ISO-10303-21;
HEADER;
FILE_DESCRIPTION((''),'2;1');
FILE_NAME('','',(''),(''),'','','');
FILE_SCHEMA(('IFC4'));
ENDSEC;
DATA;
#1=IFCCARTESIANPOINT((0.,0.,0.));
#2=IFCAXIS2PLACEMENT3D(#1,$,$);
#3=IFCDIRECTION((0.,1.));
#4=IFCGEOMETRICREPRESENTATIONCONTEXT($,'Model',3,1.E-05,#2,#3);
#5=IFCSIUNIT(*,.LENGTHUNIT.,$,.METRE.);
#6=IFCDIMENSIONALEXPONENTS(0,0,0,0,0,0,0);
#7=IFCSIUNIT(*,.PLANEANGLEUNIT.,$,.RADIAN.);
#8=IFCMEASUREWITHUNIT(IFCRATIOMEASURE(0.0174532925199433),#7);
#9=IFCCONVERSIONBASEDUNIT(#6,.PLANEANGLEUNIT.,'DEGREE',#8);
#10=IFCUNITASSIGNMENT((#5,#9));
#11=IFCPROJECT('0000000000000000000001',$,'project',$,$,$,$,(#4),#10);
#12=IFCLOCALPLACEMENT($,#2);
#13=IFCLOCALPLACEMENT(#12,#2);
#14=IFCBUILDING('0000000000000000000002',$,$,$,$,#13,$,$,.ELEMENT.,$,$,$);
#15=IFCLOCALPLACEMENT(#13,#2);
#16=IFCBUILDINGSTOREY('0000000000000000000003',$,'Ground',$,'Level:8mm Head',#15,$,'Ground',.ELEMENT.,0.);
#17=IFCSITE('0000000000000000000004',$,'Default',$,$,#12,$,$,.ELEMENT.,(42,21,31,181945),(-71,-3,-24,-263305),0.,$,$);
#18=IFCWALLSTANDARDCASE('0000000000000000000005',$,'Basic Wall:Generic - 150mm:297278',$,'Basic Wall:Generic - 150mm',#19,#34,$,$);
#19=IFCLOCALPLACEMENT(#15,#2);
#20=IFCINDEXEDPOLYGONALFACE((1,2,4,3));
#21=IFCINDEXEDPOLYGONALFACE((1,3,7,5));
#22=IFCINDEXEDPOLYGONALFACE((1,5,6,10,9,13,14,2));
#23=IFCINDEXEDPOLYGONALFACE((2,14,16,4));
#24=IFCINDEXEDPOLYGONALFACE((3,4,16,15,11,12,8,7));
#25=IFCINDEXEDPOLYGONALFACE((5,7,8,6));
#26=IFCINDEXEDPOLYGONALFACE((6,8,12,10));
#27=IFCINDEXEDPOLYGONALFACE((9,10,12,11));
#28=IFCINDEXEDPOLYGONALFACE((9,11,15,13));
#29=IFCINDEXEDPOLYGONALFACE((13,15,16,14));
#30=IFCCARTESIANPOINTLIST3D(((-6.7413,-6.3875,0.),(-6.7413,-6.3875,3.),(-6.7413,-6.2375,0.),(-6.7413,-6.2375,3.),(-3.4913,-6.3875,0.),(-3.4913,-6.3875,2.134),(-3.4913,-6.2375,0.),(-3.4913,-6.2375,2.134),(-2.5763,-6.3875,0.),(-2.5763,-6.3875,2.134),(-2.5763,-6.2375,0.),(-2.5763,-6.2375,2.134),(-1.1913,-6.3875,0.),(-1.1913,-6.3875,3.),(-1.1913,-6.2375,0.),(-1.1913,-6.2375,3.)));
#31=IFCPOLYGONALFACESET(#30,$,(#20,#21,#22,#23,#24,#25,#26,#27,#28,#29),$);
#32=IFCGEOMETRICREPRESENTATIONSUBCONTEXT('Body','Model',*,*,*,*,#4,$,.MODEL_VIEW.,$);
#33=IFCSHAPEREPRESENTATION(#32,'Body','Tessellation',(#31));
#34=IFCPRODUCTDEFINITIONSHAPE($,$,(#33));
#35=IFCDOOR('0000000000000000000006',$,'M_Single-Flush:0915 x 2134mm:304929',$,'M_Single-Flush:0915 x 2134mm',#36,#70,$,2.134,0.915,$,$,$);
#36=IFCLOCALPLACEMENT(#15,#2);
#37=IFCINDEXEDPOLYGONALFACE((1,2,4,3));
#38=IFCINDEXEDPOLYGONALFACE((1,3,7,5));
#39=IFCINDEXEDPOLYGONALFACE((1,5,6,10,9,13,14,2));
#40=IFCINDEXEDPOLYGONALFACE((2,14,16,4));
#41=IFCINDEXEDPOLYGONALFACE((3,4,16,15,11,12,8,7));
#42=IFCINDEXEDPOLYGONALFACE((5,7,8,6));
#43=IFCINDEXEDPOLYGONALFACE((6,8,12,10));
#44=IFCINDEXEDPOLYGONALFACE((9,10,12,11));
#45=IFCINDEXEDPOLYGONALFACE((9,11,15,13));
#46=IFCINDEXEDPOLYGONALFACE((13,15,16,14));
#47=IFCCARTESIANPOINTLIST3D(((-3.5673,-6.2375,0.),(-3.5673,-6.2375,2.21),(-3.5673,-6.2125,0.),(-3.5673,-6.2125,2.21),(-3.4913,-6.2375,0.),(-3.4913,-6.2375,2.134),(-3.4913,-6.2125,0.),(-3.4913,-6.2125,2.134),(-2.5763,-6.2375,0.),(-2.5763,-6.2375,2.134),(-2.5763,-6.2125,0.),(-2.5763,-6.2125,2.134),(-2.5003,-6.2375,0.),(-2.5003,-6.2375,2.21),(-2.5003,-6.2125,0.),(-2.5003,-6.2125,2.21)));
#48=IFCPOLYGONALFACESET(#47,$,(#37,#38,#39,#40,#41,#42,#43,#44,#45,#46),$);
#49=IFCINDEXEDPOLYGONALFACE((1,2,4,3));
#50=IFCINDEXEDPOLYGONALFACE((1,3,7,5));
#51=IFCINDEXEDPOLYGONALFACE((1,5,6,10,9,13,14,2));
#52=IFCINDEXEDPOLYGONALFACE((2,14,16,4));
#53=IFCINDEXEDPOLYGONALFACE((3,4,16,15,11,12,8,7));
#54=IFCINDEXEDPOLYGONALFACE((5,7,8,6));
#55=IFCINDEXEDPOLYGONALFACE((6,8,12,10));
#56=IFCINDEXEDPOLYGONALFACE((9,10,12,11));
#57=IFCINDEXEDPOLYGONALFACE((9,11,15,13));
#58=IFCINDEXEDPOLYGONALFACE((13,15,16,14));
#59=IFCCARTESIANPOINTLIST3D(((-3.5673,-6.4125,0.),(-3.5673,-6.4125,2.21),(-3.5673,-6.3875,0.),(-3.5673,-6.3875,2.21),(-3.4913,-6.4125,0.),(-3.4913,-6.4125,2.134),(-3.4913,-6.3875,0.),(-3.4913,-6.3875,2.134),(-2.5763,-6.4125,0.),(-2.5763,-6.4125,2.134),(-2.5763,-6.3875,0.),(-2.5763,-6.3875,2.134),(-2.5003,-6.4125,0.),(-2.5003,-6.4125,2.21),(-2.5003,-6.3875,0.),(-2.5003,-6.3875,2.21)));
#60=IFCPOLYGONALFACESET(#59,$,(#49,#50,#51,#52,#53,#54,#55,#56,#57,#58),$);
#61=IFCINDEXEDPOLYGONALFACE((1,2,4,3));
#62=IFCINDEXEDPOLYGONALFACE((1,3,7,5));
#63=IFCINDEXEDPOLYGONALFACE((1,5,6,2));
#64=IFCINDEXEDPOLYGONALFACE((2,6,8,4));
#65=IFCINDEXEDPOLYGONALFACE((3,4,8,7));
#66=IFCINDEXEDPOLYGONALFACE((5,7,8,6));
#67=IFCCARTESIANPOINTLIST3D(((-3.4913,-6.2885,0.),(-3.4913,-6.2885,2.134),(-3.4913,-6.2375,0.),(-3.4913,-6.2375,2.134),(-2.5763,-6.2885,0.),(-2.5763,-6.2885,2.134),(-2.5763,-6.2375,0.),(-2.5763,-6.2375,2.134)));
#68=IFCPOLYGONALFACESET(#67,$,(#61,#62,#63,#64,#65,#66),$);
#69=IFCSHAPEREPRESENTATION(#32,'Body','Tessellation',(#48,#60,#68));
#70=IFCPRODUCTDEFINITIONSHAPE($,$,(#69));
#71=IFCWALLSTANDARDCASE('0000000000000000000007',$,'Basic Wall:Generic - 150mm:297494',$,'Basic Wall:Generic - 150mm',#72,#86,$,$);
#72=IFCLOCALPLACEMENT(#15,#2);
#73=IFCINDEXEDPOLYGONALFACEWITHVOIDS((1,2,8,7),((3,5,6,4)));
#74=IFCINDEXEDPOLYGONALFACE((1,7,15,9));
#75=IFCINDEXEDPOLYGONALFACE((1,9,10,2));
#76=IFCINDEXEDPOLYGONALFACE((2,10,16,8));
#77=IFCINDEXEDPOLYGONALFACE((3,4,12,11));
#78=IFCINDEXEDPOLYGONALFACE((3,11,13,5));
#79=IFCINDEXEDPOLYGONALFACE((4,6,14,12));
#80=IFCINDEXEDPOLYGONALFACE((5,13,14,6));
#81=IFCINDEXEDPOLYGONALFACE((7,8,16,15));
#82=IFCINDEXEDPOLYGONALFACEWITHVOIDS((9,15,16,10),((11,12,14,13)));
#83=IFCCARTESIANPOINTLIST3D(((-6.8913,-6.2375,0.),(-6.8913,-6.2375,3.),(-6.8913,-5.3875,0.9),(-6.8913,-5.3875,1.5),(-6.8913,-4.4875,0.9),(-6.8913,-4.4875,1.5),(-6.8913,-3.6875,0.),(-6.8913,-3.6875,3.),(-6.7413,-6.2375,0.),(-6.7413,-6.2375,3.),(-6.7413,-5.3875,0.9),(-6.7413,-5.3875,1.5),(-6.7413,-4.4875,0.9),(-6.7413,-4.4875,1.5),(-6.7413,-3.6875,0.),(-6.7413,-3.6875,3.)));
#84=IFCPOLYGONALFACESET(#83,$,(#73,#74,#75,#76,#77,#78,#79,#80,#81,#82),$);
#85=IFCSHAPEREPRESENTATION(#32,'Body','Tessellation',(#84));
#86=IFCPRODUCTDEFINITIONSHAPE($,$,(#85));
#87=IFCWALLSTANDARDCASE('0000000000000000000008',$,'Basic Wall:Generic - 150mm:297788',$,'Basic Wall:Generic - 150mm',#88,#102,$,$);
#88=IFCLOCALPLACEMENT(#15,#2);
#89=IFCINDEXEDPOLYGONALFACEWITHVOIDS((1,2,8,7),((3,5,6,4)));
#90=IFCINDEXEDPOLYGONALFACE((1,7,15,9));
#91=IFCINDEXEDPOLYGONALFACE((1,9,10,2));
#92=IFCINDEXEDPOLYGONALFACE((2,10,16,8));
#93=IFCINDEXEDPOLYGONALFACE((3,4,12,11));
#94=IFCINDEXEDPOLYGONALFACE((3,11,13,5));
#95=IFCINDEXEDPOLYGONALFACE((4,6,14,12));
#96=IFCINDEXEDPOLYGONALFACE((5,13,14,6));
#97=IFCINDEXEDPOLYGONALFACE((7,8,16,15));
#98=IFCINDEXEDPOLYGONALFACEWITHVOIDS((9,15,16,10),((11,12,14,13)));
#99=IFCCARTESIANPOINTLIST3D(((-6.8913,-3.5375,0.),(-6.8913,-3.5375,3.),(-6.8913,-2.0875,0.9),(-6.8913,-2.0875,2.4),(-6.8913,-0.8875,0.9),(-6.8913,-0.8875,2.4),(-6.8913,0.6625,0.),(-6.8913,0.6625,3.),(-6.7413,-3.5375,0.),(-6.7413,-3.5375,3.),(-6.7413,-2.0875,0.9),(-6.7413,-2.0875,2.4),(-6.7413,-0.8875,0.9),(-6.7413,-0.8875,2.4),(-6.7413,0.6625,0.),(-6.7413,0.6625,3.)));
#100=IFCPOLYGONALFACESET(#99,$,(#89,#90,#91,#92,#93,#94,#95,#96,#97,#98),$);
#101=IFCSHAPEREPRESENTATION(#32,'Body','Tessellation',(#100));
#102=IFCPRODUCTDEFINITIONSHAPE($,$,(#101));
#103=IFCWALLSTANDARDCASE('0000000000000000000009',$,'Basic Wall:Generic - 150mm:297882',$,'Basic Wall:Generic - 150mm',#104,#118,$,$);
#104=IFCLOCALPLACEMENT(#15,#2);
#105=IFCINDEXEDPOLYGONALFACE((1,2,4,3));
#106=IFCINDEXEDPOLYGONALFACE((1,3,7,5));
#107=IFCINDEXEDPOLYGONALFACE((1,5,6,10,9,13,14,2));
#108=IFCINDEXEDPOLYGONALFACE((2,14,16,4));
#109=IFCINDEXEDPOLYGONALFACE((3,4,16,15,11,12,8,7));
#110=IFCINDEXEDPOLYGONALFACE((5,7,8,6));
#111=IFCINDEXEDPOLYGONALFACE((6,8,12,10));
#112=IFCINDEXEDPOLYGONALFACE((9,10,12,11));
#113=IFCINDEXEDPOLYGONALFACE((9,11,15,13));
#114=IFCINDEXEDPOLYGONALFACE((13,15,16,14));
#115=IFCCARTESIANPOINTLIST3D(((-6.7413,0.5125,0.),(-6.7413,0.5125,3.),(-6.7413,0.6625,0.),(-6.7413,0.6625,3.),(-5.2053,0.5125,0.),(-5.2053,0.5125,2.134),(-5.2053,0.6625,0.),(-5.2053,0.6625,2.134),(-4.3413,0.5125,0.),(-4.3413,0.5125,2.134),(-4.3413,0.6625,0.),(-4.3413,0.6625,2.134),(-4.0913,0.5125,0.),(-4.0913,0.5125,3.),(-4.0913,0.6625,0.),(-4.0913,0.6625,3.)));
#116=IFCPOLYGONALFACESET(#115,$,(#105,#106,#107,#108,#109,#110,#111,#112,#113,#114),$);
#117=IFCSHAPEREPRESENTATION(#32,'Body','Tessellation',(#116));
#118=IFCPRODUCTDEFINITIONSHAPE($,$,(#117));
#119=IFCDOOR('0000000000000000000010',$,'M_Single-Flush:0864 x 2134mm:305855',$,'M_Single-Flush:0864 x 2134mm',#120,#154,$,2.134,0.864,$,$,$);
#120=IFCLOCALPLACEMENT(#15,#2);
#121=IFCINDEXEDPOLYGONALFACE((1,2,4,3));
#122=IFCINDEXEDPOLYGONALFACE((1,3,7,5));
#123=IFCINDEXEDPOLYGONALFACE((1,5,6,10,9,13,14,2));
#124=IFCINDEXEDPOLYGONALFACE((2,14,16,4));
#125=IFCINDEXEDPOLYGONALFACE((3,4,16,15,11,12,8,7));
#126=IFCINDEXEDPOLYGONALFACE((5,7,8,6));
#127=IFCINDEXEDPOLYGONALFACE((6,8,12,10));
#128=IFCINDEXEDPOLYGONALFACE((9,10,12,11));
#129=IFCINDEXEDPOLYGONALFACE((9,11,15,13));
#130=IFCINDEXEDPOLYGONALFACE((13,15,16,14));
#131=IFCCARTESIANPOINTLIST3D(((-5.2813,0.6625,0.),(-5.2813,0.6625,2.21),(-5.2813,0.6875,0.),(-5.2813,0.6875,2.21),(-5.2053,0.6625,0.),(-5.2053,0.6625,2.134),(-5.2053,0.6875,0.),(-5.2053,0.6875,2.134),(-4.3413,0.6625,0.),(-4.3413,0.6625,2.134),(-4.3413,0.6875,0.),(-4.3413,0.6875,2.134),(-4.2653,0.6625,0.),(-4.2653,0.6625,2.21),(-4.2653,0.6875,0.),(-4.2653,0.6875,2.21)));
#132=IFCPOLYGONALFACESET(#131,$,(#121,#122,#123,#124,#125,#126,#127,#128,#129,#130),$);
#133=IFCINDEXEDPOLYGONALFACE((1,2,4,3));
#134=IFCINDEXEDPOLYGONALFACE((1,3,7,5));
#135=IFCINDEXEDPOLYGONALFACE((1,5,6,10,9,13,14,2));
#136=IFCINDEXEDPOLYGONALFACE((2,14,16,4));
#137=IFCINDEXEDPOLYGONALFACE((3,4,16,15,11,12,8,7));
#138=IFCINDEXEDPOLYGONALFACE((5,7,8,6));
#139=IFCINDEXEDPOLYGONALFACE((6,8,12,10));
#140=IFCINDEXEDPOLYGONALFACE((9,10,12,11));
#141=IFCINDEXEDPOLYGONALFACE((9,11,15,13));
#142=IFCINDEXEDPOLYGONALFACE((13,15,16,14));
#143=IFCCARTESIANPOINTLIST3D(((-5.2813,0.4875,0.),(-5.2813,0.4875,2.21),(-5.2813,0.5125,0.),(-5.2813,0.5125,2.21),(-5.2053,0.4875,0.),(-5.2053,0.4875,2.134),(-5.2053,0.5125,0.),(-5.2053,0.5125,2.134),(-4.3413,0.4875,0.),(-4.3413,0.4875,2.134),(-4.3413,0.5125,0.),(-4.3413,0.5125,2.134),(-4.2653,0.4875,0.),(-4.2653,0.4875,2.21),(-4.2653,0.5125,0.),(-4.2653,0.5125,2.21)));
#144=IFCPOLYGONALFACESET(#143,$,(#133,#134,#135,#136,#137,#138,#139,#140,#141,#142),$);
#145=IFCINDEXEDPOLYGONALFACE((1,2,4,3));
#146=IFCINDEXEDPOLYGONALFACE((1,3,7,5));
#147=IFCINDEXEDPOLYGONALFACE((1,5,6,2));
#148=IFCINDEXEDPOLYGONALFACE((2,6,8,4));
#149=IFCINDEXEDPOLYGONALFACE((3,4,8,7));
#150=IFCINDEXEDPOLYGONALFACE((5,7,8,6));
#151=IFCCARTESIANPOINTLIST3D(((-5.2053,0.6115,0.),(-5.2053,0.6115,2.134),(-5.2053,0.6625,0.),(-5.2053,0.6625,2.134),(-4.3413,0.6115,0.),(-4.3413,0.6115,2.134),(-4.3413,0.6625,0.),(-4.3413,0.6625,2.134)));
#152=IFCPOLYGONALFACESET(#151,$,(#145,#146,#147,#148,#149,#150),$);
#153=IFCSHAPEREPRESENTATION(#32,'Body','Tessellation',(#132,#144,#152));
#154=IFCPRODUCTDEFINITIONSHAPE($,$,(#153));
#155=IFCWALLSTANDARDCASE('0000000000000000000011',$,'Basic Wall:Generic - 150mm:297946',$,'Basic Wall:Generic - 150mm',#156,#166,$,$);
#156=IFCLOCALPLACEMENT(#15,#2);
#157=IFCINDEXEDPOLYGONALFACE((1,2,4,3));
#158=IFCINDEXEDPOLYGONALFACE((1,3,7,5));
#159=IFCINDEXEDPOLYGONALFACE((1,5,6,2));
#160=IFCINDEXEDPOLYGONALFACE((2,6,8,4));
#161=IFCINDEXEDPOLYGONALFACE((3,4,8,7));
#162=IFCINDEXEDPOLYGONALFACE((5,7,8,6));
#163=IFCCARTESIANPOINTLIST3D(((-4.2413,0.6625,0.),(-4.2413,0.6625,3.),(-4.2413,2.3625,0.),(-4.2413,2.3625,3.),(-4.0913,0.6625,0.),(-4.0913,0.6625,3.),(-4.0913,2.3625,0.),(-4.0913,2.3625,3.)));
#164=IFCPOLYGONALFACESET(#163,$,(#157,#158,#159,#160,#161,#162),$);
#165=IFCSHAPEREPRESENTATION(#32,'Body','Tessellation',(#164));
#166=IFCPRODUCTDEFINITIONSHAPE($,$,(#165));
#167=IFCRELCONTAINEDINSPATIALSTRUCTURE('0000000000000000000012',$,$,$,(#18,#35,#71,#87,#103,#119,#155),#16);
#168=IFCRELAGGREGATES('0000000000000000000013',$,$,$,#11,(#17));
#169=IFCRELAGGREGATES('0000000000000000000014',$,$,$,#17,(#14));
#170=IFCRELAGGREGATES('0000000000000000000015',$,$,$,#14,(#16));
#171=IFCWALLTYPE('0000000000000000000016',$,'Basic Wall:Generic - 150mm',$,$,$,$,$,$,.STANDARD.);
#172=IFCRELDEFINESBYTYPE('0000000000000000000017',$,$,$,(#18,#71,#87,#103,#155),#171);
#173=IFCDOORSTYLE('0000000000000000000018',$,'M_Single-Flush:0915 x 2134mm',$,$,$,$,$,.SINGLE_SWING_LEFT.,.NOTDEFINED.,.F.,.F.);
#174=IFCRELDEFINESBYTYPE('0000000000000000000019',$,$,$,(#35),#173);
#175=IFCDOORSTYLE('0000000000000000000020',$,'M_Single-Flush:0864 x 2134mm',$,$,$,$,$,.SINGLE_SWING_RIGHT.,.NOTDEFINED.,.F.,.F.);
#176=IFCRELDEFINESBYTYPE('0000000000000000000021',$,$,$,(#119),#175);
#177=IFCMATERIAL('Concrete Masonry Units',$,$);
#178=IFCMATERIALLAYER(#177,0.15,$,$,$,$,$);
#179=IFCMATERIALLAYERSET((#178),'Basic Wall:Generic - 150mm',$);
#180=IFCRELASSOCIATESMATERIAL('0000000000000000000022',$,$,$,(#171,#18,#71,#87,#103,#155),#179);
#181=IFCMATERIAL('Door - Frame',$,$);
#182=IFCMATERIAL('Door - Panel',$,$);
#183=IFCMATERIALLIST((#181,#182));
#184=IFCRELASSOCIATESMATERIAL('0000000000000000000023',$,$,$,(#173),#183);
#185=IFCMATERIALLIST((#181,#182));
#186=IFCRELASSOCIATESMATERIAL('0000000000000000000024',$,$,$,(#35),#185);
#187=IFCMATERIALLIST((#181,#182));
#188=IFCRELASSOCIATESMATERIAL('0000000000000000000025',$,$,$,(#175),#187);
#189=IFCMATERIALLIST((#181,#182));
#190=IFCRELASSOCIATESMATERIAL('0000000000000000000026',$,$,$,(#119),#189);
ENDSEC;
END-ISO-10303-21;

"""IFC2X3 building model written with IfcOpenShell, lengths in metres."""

from ifc_helpers import new_model, entity, si_unit, converted_unit, direction, frame, frame_2d, origin, place, context, subcontext, project, spatial, polyline, rectangle, outline, extrude, source, transform, mapped, material, material_list, layer, layer_set, layer_usage, type_object, type_shapes, element, fill, save


model = new_model("IFC2X3")

# Units and contexts
model_context = context("Model", 3, precision=1e-05, world=origin(), true_north=direction((0.0, 1.0)))
body_context = subcontext(model_context, "Body", "Model", "MODEL_VIEW")
ifc_project = project(units=[si_unit("LENGTHUNIT", "METRE"), converted_unit("PLANEANGLEUNIT", "DEGREE", entity("IfcRatioMeasure", 0.0174532925199433), si_unit("PLANEANGLEUNIT", "RADIAN"), dimensions=[0, 0, 0, 0, 0, 0, 0])], contexts=[model_context])

# Site, building, storey
site_placement = place(None, origin())
site = spatial("IfcSite", under=ifc_project, at=site_placement, Name="Default", CompositionType="ELEMENT", RefLatitude=(42, 21, 31, 181945), RefLongitude=(-71, -3, -24, -263305), RefElevation=0.0)
building_placement = place(site_placement, origin())
building = spatial("IfcBuilding", under=site, at=building_placement, CompositionType="ELEMENT")
storey_placement = place(building_placement, origin())
storey = spatial("IfcBuildingStorey", under=building, at=storey_placement, Name="Ground", ObjectType="Level:8mm Head", LongName="Ground", CompositionType="ELEMENT", Elevation=0.0)

# Wall, opening, door
ifc_material_1 = material(Name="Concrete Masonry Units")
ifc_layer = layer(ifc_material_1, 0.15)
ifc_layer_set = layer_set([ifc_layer], Name="Basic Wall:Generic - 150mm")
ifc_layer_usage_1 = layer_usage(ifc_layer_set, "AXIS2", "POSITIVE", -0.075)
wall_type = type_object("IfcWallType", Name="Basic Wall:Generic - 150mm", PredefinedType="STANDARD", material=ifc_layer_set)
wall_1_placement = place(storey_placement, frame((-6.7413, -6.3125, 0.0)))
wall_1 = element("IfcWallStandardCase", 1, at=wall_1_placement, inside=storey, type_object=wall_type, material=ifc_layer_usage_1, Name="Basic Wall:Generic - 150mm:297278", ObjectType="Basic Wall:Generic - 150mm", context=body_context, shape_type="SweptSolid", body=[
    extrude(rectangle(XDim=5.55, YDim=0.15, at=frame_2d((2.775, 0.0), x_axis=(-1.0, 0.0))), origin(), (0.0, 0.0, 1.0), 3.0),
])
opening_1_placement = place(wall_1_placement, frame((3.25, -0.075, 0.0)))
opening_1 = element("IfcOpeningElement", 2, at=opening_1_placement, cuts=wall_1, ObjectType="Opening", context=body_context, shape_type="SweptSolid", body=[
    extrude(rectangle(XDim=0.915, YDim=2.134, at=frame_2d((1.067, 0.4575), x_axis=(0.0, -1.0))), frame((0.0, 0.0, 0.0), z_axis=(0.0, 1.0, 0.0), x_axis=(0.0, 0.0, 1.0)), (0.0, 0.0, 1.0), 0.15),
])
ifc_material_2 = material(Name="Door - Frame")
ifc_material_3 = material(Name="Door - Panel")
ifc_material_list_1 = material_list([ifc_material_2, ifc_material_3])
ifc_material_list_2 = material_list([ifc_material_2, ifc_material_3])
door_style_1 = type_object("IfcDoorStyle", Name="M_Single-Flush:0915 x 2134mm", ConstructionType="NOTDEFINED", OperationType="SINGLE_SWING_LEFT", ParameterTakesPrecedence=False, Sizeable=False, material=ifc_material_list_2)
shared_shape_1 = source(origin(), body_context, "Body", "SweptSolid", [
    extrude(outline(polyline([(-0.5335, -1.124), (0.5335, -1.124), (0.5335, 1.086), (0.4575, 1.086), (0.4575, -1.048), (-0.4575, -1.048), (-0.4575, 1.086), (-0.5335, 1.086), (-0.5335, -1.124)])), frame((0.4575, 0.175, 1.086), z_axis=(0.0, -1.0, 0.0), x_axis=(-1.0, 0.0, 0.0)), (0.0, 0.0, 1.0), 0.025),
    extrude(outline(polyline([(-1.124, -0.5335), (1.086, -0.5335), (1.086, -0.4575), (-1.048, -0.4575), (-1.048, 0.4575), (1.086, 0.4575), (1.086, 0.5335), (-1.124, 0.5335), (-1.124, -0.5335)])), frame((0.4575, 0.0, 1.086), z_axis=(0.0, -1.0, 0.0), x_axis=(0.0, 0.0, -1.0)), (0.0, 0.0, 1.0), 0.025),
    extrude(rectangle(XDim=0.915, YDim=0.051, at=frame_2d((0.0, 0.0), x_axis=(1.0, 0.0))), frame((0.4575, 0.1245, 0.0)), (0.0, 0.0, 1.0), 2.134),
])
type_shapes(door_style_1, [shared_shape_1])
door_1_placement = place(opening_1_placement, origin())
door_1 = element("IfcDoor", 3, at=door_1_placement, inside=storey, type_object=door_style_1, material=ifc_material_list_1, Name="M_Single-Flush:0915 x 2134mm:304929", ObjectType="M_Single-Flush:0915 x 2134mm", OverallHeight=2.134, OverallWidth=0.915, context=body_context, shape_type="MappedRepresentation", body=[
    mapped(shared_shape_1, transform((0.0, 0.0, 0.0), scale=1.0)),
])
fill(opening_1, door_1)

# Walls, openings
ifc_layer_usage_2 = layer_usage(ifc_layer_set, "AXIS2", "NEGATIVE", 0.075)
wall_2_placement = place(storey_placement, frame((-6.8163, -3.6875, 0.0), z_axis=(0.0, 0.0, 1.0), x_axis=(0.0, -1.0, 0.0)))
wall_2 = element("IfcWallStandardCase", 4, at=wall_2_placement, inside=storey, type_object=wall_type, material=ifc_layer_usage_2, Name="Basic Wall:Generic - 150mm:297494", ObjectType="Basic Wall:Generic - 150mm", context=body_context, shape_type="SweptSolid", body=[
    extrude(rectangle(XDim=2.55, YDim=0.15, at=frame_2d((1.275, 0.0), x_axis=(-1.0, 0.0))), origin(), (0.0, 0.0, 1.0), 3.0),
])
opening_2_placement = place(wall_2_placement, frame((0.8, -0.075, 0.9)))
element("IfcOpeningElement", 5, at=opening_2_placement, cuts=wall_2, ObjectType="Opening", context=body_context, shape_type="SweptSolid", body=[
    extrude(rectangle(XDim=0.6, YDim=0.9, at=frame_2d((0.3, 0.45), x_axis=(-1.0, 0.0))), frame((0.0, 0.0, 0.0), z_axis=(0.0, 1.0, 0.0), x_axis=(0.0, 0.0, 1.0)), (0.0, 0.0, 1.0), 0.15),
])
ifc_layer_usage_3 = layer_usage(ifc_layer_set, "AXIS2", "NEGATIVE", 0.075)
wall_3_placement = place(storey_placement, frame((-6.8163, -3.5375, 0.0), z_axis=(0.0, 0.0, 1.0), x_axis=(0.0, 1.0, 0.0)))
wall_3 = element("IfcWallStandardCase", 6, at=wall_3_placement, inside=storey, type_object=wall_type, material=ifc_layer_usage_3, Name="Basic Wall:Generic - 150mm:297788", ObjectType="Basic Wall:Generic - 150mm", context=body_context, shape_type="SweptSolid", body=[
    extrude(rectangle(XDim=4.2, YDim=0.15, at=frame_2d((2.1, 0.0), x_axis=(-1.0, 0.0))), origin(), (0.0, 0.0, 1.0), 3.0),
])
opening_3_placement = place(wall_3_placement, frame((2.65, 0.075, 0.9)))
element("IfcOpeningElement", 7, at=opening_3_placement, cuts=wall_3, ObjectType="Opening", context=body_context, shape_type="SweptSolid", body=[
    extrude(rectangle(XDim=1.5, YDim=1.2, at=frame_2d((0.75, 0.6), x_axis=(-1.0, 0.0))), frame((0.0, 0.0, 0.0), z_axis=(0.0, -1.0, 0.0), x_axis=(0.0, 0.0, 1.0)), (0.0, 0.0, 1.0), 0.15),
])

# Wall, opening, door
ifc_layer_usage_4 = layer_usage(ifc_layer_set, "AXIS2", "POSITIVE", -0.075)
wall_4_placement = place(storey_placement, frame((-6.7413, 0.5875, 0.0)))
wall_4 = element("IfcWallStandardCase", 8, at=wall_4_placement, inside=storey, type_object=wall_type, material=ifc_layer_usage_4, Name="Basic Wall:Generic - 150mm:297882", ObjectType="Basic Wall:Generic - 150mm", context=body_context, shape_type="SweptSolid", body=[
    extrude(rectangle(XDim=2.65, YDim=0.15, at=frame_2d((1.325, 0.0), x_axis=(-1.0, 0.0))), origin(), (0.0, 0.0, 1.0), 3.0),
])
opening_4_placement = place(wall_4_placement, frame((1.536, -0.075, 0.0)))
opening_4 = element("IfcOpeningElement", 9, at=opening_4_placement, cuts=wall_4, ObjectType="Opening", context=body_context, shape_type="SweptSolid", body=[
    extrude(rectangle(XDim=0.864, YDim=2.134, at=frame_2d((1.067, 0.432), x_axis=(0.0, 1.0))), frame((0.0, 0.0, 0.0), z_axis=(0.0, 1.0, 0.0), x_axis=(0.0, 0.0, 1.0)), (0.0, 0.0, 1.0), 0.15),
])
ifc_material_list_3 = material_list([ifc_material_2, ifc_material_3])
ifc_material_list_4 = material_list([ifc_material_2, ifc_material_3])
door_style_2 = type_object("IfcDoorStyle", Name="M_Single-Flush:0864 x 2134mm", ConstructionType="NOTDEFINED", OperationType="SINGLE_SWING_RIGHT", ParameterTakesPrecedence=False, Sizeable=False, material=ifc_material_list_4)
shared_shape_2 = source(origin(), body_context, "Body", "SweptSolid", [
    extrude(outline(polyline([(-0.508, -1.124), (0.508, -1.124), (0.508, 1.086), (0.432, 1.086), (0.432, -1.048), (-0.432, -1.048), (-0.432, 1.086), (-0.508, 1.086), (-0.508, -1.124)])), frame((0.432, 0.15, 1.086), z_axis=(0.0, 1.0, 0.0), x_axis=(1.0, 0.0, 0.0)), (0.0, 0.0, 1.0), 0.025),
    extrude(outline(polyline([(-1.124, -0.508), (1.086, -0.508), (1.086, -0.432), (-1.048, -0.432), (-1.048, 0.432), (1.086, 0.432), (1.086, 0.508), (-1.124, 0.508), (-1.124, -0.508)])), frame((0.432, -0.025, 1.086), z_axis=(0.0, 1.0, 0.0), x_axis=(0.0, 0.0, -1.0)), (0.0, 0.0, 1.0), 0.025),
    extrude(rectangle(XDim=0.051, YDim=0.864, at=frame_2d((0.0, 0.0), x_axis=(1.0, 0.0))), frame((0.432, 0.1245, 0.0), z_axis=(0.0, 0.0, 1.0), x_axis=(0.0, 1.0, 0.0)), (0.0, 0.0, 1.0), 2.134),
])
type_shapes(door_style_2, [shared_shape_2])
door_2_placement = place(opening_4_placement, origin())
door_2 = element("IfcDoor", 10, at=door_2_placement, inside=storey, type_object=door_style_2, material=ifc_material_list_3, Name="M_Single-Flush:0864 x 2134mm:305855", ObjectType="M_Single-Flush:0864 x 2134mm", OverallHeight=2.134, OverallWidth=0.864, context=body_context, shape_type="MappedRepresentation", body=[
    mapped(shared_shape_2, transform((0.0, 0.0, 0.0), scale=1.0)),
])
fill(opening_4, door_2)

# Wall
ifc_layer_usage_5 = layer_usage(ifc_layer_set, "AXIS2", "NEGATIVE", 0.075)
wall_5_placement = place(storey_placement, frame((-4.1663, 0.6625, 0.0), z_axis=(0.0, 0.0, 1.0), x_axis=(0.0, 1.0, 0.0)))
element("IfcWallStandardCase", 11, at=wall_5_placement, inside=storey, type_object=wall_type, material=ifc_layer_usage_5, Name="Basic Wall:Generic - 150mm:297946", ObjectType="Basic Wall:Generic - 150mm", context=body_context, shape_type="SweptSolid", body=[
    extrude(rectangle(XDim=1.7, YDim=0.15, at=frame_2d((0.85, 0.0), x_axis=(-1.0, 0.0))), origin(), (0.0, 0.0, 1.0), 3.0),
])

save(model, "model.ifc")
